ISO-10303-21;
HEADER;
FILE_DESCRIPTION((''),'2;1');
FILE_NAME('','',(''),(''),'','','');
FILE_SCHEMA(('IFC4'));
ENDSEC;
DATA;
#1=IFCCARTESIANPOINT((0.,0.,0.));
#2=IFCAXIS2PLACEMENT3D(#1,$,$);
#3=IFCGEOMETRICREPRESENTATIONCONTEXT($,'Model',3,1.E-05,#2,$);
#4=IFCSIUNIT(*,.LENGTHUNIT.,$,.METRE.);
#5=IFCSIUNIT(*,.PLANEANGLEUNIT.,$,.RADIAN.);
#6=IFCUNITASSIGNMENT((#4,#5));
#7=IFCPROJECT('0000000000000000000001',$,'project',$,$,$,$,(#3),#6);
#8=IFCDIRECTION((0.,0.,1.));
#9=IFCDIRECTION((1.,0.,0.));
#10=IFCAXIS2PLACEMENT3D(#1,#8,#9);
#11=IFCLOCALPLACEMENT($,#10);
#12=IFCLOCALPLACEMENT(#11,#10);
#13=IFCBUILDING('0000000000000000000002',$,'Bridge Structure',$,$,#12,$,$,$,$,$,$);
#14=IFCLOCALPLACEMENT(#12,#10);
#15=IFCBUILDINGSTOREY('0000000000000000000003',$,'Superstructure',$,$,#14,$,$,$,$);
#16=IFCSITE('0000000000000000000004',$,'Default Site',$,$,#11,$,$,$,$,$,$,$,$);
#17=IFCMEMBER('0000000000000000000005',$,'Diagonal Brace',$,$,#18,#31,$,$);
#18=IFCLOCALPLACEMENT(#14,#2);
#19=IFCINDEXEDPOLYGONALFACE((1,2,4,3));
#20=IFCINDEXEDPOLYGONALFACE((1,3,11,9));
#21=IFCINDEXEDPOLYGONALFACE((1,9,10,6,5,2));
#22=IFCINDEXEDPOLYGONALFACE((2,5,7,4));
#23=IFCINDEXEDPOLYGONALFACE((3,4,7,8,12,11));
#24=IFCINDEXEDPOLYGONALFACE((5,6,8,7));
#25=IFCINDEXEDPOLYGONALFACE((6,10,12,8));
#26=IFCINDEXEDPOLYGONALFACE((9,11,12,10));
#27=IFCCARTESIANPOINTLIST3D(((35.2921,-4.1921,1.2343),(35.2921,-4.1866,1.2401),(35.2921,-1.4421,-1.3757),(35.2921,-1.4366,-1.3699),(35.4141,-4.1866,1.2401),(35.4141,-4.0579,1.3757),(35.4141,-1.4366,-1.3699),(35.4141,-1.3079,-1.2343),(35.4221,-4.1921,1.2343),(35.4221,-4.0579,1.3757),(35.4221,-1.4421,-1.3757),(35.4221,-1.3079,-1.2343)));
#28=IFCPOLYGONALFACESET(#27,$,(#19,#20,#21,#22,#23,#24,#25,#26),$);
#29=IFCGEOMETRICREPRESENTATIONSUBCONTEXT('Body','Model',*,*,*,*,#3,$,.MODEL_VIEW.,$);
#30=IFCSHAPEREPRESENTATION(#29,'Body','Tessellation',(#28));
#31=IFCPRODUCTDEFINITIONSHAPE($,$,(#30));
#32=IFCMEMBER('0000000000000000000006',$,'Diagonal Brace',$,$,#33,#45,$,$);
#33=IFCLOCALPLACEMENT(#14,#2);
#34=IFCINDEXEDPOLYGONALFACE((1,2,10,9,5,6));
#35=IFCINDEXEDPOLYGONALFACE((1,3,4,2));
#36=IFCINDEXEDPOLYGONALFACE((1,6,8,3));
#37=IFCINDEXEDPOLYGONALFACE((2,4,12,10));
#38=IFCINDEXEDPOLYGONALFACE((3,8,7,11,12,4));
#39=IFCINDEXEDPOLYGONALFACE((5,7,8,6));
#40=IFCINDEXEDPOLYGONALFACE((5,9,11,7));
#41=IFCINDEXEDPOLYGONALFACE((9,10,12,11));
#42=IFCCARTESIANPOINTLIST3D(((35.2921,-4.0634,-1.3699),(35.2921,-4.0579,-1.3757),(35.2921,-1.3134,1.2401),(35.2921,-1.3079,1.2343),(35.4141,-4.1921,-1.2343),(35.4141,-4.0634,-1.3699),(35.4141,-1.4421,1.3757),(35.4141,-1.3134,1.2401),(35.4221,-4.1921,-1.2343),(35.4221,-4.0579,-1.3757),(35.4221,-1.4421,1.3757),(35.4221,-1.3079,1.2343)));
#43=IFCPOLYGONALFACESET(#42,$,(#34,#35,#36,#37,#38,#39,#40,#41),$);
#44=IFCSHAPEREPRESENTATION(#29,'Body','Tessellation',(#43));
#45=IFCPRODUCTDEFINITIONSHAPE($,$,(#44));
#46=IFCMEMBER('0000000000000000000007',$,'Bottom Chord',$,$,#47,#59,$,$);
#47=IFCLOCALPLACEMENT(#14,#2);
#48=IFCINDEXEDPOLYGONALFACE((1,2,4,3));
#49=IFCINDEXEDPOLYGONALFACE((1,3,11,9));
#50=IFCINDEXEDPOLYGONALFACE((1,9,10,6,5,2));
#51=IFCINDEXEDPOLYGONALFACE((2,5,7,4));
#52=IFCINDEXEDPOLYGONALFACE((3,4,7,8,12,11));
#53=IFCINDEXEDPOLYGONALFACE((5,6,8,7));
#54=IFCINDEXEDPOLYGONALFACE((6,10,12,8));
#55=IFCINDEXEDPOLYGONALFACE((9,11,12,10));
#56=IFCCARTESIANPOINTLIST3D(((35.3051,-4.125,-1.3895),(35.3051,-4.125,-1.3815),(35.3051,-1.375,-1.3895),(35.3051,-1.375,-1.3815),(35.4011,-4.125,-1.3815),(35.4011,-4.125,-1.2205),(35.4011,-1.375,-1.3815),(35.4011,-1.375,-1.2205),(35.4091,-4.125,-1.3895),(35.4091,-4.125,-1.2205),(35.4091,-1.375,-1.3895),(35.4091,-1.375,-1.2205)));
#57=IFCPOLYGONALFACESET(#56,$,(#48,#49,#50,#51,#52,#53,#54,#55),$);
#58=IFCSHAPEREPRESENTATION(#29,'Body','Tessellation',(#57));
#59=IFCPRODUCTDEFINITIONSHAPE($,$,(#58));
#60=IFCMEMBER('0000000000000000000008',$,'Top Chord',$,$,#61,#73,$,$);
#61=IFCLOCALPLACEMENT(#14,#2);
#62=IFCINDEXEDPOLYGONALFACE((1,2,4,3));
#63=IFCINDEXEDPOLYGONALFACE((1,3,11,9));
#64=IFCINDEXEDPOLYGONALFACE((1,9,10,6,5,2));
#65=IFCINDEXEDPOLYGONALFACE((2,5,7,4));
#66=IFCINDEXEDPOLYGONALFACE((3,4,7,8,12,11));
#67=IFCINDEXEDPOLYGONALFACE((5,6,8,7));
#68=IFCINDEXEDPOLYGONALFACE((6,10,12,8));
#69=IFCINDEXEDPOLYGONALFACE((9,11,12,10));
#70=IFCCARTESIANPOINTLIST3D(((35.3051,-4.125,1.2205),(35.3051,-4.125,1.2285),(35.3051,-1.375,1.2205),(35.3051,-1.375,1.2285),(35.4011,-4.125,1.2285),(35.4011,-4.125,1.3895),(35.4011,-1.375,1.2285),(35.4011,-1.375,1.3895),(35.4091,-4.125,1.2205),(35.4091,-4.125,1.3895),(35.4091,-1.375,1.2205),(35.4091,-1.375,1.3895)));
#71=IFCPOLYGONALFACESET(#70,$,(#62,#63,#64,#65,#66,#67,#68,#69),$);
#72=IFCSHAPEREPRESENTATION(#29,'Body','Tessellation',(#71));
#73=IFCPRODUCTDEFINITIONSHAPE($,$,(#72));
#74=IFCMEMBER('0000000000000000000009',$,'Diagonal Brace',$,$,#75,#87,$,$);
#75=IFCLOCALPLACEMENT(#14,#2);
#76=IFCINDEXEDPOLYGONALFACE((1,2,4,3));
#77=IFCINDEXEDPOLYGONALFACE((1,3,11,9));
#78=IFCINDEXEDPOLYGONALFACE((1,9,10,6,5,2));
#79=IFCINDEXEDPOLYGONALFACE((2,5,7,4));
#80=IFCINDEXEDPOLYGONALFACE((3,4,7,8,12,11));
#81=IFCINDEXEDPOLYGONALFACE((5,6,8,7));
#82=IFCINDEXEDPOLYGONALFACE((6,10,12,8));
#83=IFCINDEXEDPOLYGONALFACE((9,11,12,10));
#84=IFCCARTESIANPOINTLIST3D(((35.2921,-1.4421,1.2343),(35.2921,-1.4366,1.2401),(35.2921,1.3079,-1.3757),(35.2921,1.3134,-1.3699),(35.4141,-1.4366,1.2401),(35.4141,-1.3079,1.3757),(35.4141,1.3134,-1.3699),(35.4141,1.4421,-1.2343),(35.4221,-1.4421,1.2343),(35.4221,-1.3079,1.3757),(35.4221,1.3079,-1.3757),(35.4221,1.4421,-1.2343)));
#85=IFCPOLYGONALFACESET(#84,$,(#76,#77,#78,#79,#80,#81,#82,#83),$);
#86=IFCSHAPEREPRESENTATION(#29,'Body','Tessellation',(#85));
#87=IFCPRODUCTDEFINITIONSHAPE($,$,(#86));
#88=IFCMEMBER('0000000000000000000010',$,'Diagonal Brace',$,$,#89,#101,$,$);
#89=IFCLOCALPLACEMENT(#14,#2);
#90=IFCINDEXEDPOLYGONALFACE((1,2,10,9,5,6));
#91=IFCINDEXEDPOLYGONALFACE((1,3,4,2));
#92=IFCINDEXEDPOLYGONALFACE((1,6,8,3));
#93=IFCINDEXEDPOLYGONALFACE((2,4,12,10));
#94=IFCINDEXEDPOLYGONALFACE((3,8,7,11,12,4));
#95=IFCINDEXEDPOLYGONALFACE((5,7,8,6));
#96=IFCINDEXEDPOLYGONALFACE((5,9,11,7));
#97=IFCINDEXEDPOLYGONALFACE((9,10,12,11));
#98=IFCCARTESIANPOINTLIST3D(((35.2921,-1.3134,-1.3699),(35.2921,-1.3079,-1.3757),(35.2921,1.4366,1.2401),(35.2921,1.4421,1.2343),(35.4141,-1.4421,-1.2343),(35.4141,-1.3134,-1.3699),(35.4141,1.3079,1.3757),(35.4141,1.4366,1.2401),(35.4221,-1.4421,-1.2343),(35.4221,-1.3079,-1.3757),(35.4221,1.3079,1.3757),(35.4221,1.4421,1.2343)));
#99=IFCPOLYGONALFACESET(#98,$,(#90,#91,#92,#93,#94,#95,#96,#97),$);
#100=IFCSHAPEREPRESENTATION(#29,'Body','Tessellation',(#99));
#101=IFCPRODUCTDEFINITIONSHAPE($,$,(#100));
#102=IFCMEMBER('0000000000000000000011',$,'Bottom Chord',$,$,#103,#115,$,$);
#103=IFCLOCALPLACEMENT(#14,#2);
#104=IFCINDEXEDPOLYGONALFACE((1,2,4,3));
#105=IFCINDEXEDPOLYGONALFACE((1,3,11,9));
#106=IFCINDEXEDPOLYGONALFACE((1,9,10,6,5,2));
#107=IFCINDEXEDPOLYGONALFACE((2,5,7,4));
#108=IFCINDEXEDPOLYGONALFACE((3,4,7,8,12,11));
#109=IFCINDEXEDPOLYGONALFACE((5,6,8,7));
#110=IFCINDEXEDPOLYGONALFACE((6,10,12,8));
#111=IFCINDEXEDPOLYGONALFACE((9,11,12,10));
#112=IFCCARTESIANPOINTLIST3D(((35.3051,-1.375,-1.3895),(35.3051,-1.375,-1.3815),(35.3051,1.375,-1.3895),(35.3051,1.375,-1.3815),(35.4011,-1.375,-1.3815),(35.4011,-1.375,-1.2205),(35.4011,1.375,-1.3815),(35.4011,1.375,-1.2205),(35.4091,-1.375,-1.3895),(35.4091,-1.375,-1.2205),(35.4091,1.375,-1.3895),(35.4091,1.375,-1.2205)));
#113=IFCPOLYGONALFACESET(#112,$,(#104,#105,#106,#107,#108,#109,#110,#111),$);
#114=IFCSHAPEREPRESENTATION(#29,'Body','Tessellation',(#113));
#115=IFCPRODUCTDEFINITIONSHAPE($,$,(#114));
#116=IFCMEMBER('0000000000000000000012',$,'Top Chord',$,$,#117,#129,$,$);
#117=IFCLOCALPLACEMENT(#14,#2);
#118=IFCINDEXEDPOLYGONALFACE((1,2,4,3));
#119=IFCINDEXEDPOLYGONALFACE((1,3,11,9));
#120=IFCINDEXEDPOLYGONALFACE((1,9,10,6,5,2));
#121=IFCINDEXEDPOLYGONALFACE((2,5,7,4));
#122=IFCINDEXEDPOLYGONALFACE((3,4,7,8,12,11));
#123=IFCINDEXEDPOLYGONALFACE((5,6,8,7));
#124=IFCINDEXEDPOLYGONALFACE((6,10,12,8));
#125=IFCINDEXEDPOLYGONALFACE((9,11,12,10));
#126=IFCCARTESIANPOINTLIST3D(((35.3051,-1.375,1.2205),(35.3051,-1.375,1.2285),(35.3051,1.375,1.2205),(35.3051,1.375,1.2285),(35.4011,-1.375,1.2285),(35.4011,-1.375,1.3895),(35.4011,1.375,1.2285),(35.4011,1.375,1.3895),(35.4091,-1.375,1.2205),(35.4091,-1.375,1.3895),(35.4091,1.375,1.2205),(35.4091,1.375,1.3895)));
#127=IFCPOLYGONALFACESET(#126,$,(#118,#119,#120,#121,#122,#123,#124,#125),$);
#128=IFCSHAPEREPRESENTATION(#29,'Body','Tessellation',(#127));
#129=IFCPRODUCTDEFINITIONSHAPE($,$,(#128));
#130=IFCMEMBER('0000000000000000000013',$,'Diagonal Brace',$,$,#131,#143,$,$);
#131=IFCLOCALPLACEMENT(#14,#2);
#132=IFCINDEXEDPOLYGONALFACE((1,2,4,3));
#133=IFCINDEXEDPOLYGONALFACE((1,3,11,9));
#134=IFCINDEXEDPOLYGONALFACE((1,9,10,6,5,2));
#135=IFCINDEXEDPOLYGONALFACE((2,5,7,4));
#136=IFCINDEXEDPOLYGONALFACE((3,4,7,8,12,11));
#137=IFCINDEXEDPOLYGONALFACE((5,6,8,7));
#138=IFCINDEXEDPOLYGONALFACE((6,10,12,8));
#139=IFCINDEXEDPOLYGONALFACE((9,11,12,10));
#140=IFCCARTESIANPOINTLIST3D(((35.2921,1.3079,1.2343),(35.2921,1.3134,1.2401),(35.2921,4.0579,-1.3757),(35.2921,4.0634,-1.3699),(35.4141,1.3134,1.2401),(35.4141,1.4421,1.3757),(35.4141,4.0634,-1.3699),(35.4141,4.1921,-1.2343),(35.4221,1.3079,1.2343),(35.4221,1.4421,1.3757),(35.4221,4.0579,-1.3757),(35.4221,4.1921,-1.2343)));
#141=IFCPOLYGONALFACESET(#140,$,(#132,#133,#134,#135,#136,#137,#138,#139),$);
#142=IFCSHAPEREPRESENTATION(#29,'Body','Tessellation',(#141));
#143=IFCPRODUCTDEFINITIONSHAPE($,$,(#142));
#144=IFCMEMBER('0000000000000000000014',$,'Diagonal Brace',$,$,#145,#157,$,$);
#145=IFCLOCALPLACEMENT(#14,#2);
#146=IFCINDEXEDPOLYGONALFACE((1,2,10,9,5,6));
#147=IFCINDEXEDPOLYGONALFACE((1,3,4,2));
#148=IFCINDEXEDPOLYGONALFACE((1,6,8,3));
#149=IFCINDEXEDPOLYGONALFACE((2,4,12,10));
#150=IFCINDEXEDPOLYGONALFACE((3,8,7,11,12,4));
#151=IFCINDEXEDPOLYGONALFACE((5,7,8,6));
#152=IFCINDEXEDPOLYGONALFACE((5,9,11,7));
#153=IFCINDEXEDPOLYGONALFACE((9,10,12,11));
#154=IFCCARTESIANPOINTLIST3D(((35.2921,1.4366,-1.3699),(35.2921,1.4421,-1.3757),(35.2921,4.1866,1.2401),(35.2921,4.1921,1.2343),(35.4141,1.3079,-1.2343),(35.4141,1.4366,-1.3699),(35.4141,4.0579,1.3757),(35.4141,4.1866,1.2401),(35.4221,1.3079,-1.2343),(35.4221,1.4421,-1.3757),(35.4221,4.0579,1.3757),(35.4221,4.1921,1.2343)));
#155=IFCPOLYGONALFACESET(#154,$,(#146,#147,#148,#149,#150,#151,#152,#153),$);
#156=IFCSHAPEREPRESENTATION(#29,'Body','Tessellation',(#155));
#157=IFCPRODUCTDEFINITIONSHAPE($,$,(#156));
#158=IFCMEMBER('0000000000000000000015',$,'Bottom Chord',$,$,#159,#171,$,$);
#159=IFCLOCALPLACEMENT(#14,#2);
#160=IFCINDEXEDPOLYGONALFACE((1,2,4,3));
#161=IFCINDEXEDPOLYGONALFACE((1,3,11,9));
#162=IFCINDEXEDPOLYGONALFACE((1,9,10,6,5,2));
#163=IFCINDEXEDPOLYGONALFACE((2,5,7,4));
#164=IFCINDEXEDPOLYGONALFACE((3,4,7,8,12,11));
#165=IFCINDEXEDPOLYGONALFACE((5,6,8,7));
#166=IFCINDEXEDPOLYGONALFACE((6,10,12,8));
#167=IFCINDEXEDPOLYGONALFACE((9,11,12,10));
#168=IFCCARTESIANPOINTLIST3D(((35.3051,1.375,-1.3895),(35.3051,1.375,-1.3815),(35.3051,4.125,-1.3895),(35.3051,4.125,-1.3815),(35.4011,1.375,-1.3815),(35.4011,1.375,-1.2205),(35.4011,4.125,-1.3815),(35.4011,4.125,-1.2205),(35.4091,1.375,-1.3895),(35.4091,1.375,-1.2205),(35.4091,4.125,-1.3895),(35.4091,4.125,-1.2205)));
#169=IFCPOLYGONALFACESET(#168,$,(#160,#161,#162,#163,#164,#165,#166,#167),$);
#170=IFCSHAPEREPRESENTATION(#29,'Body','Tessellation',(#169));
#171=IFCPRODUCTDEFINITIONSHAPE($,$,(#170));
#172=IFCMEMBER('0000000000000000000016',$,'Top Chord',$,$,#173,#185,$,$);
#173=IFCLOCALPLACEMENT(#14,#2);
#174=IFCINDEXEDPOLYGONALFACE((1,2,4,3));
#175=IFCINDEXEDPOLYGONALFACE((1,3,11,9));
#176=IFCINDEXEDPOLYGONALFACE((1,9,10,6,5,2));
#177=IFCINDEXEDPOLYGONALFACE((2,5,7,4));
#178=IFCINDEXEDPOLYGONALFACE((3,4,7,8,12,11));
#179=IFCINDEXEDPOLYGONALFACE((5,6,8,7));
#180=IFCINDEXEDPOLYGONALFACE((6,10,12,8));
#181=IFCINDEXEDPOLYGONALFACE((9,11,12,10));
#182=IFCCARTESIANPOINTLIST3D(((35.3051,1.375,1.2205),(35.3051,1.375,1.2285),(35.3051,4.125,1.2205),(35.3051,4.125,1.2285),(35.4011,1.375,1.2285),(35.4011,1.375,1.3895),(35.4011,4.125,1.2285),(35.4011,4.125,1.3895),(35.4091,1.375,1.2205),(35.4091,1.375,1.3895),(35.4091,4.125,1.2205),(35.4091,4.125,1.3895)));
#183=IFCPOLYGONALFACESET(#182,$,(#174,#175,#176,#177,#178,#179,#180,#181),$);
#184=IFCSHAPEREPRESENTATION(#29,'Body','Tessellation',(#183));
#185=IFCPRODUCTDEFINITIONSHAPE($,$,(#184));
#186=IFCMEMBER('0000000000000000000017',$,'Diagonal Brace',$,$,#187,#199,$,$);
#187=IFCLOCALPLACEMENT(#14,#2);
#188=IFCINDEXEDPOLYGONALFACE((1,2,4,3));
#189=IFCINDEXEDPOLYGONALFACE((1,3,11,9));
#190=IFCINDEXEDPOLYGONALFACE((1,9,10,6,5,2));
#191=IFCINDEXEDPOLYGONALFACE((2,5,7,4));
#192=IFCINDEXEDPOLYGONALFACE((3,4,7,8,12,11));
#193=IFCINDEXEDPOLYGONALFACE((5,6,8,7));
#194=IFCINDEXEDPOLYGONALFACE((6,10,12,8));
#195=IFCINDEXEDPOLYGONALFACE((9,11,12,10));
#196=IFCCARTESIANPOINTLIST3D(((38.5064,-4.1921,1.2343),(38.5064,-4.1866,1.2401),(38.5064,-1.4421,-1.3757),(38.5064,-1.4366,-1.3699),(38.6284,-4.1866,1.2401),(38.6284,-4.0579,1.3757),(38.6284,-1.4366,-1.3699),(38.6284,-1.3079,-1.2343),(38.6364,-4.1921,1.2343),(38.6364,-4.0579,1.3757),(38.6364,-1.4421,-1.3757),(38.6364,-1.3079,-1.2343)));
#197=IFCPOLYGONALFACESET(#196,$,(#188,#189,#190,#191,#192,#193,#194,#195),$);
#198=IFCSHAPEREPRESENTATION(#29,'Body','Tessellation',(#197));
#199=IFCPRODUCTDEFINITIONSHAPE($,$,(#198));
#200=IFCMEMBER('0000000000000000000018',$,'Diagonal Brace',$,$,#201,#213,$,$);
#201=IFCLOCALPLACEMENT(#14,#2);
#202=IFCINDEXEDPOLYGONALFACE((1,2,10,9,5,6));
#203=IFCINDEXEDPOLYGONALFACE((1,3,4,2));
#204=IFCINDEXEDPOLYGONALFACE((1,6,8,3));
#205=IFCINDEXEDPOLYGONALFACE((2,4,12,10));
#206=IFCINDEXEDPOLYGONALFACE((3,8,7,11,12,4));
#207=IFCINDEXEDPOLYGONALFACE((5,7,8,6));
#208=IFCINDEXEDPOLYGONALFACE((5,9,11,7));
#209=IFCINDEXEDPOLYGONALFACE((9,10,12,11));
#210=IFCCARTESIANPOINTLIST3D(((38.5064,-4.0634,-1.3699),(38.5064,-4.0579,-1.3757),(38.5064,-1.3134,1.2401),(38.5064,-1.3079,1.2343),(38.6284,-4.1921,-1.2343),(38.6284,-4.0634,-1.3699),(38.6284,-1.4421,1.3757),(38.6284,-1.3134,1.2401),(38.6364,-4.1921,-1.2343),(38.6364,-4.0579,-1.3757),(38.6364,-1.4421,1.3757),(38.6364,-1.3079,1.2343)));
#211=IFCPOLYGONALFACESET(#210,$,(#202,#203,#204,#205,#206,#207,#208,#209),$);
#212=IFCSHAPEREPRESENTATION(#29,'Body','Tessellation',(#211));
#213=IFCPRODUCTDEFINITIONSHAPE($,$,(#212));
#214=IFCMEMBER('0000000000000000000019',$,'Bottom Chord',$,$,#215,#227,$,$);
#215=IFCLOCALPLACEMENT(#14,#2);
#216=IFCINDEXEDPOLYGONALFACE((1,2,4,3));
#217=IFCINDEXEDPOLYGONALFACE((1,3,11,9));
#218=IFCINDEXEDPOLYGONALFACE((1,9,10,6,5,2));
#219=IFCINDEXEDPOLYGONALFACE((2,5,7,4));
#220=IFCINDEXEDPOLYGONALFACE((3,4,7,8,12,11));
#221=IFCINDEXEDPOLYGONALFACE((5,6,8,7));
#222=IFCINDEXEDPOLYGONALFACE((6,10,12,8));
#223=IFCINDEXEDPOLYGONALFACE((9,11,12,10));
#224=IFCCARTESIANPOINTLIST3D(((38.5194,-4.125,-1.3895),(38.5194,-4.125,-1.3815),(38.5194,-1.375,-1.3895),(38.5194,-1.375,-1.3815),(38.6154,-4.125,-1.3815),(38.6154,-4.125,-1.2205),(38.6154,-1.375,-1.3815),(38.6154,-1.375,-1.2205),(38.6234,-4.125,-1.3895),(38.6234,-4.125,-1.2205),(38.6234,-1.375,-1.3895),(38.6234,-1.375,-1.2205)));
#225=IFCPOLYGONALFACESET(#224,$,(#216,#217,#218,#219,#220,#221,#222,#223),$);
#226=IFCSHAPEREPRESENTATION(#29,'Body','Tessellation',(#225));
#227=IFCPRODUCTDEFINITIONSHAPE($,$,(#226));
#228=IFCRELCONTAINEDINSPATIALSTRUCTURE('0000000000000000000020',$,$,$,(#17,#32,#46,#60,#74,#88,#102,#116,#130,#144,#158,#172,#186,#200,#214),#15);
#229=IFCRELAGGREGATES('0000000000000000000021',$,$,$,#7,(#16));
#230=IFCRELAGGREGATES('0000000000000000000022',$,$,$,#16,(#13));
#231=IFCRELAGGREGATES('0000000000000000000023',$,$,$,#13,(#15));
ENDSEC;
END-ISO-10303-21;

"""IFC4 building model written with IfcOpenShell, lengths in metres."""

from ifc_helpers import new_model, si_unit, frame, origin, origin_with_axes, origin_2d_with_axis, place, context, subcontext, project, spatial, l_section, extrude, element, save


model = new_model("IFC4")

# Units and contexts
model_context = context("Model", 3, precision=1e-05, world=origin())
body_context = subcontext(model_context, "Body", "Model", "MODEL_VIEW")
ifc_project = project(units=[si_unit("LENGTHUNIT", "METRE"), si_unit("PLANEANGLEUNIT", "RADIAN")], contexts=[model_context])

# Site, building, storey
site_placement = place(None, origin_with_axes())
site = spatial("IfcSite", under=ifc_project, at=site_placement, Name="Default Site")
building_placement = place(site_placement, origin_with_axes())
building = spatial("IfcBuilding", under=site, at=building_placement, Name="Bridge Structure")
storey_placement = place(building_placement, origin_with_axes())
storey = spatial("IfcBuildingStorey", under=building, at=storey_placement, Name="Superstructure")

# Members
for number, where, z_axis, x_axis, name in (
    (1, (35.3571, -4.125, 1.305), (0.0, 0.725329, -0.688403), (-1.0, 0.0, 0.0), "Diagonal Brace"),
    (2, (35.3571, -4.125, -1.305), (0.0, 0.725329, 0.688403), (-1.0, 0.0, 0.0), "Diagonal Brace"),
):
    element("IfcMember", number, at=place(storey_placement, frame(where, z_axis=z_axis, x_axis=x_axis)), inside=storey, Name=name, context=body_context, shape_type="SweptSolid", body=[
        extrude(l_section(Depth=0.195, Width=0.13, Thickness=0.008, at=origin_2d_with_axis()), origin_with_axes(), (0.0, 0.0, 1.0), 3.7914),
    ])
for number, where, z_axis, x_axis, name in (
    (3, (35.3571, -4.125, -1.305), (0.0, 1.0, 0.0), (-1.0, 0.0, 0.0), "Bottom Chord"),
    (4, (35.3571, -4.125, 1.305), (0.0, 1.0, 0.0), (-1.0, 0.0, 0.0), "Top Chord"),
):
    element("IfcMember", number, at=place(storey_placement, frame(where, z_axis=z_axis, x_axis=x_axis)), inside=storey, Name=name, context=body_context, shape_type="SweptSolid", body=[
        extrude(l_section(Depth=0.169, Width=0.104, Thickness=0.008, at=origin_2d_with_axis()), origin_with_axes(), (0.0, 0.0, 1.0), 2.75),
    ])
for number, where, z_axis, x_axis, name in (
    (5, (35.3571, -1.375, 1.305), (0.0, 0.725329, -0.688403), (-1.0, 0.0, 0.0), "Diagonal Brace"),
    (6, (35.3571, -1.375, -1.305), (0.0, 0.725329, 0.688403), (-1.0, 0.0, 0.0), "Diagonal Brace"),
):
    element("IfcMember", number, at=place(storey_placement, frame(where, z_axis=z_axis, x_axis=x_axis)), inside=storey, Name=name, context=body_context, shape_type="SweptSolid", body=[
        extrude(l_section(Depth=0.195, Width=0.13, Thickness=0.008, at=origin_2d_with_axis()), origin_with_axes(), (0.0, 0.0, 1.0), 3.7914),
    ])
for number, where, z_axis, x_axis, name in (
    (7, (35.3571, -1.375, -1.305), (0.0, 1.0, 0.0), (-1.0, 0.0, 0.0), "Bottom Chord"),
    (8, (35.3571, -1.375, 1.305), (0.0, 1.0, 0.0), (-1.0, 0.0, 0.0), "Top Chord"),
):
    element("IfcMember", number, at=place(storey_placement, frame(where, z_axis=z_axis, x_axis=x_axis)), inside=storey, Name=name, context=body_context, shape_type="SweptSolid", body=[
        extrude(l_section(Depth=0.169, Width=0.104, Thickness=0.008, at=origin_2d_with_axis()), origin_with_axes(), (0.0, 0.0, 1.0), 2.75),
    ])
for number, where, z_axis, x_axis, name in (
    (9, (35.3571, 1.375, 1.305), (0.0, 0.725329, -0.688403), (-1.0, 0.0, 0.0), "Diagonal Brace"),
    (10, (35.3571, 1.375, -1.305), (0.0, 0.725329, 0.688403), (-1.0, 0.0, 0.0), "Diagonal Brace"),
):
    element("IfcMember", number, at=place(storey_placement, frame(where, z_axis=z_axis, x_axis=x_axis)), inside=storey, Name=name, context=body_context, shape_type="SweptSolid", body=[
        extrude(l_section(Depth=0.195, Width=0.13, Thickness=0.008, at=origin_2d_with_axis()), origin_with_axes(), (0.0, 0.0, 1.0), 3.7914),
    ])
for number, where, z_axis, x_axis, name in (
    (11, (35.3571, 1.375, -1.305), (0.0, 1.0, 0.0), (-1.0, 0.0, 0.0), "Bottom Chord"),
    (12, (35.3571, 1.375, 1.305), (0.0, 1.0, 0.0), (-1.0, 0.0, 0.0), "Top Chord"),
):
    element("IfcMember", number, at=place(storey_placement, frame(where, z_axis=z_axis, x_axis=x_axis)), inside=storey, Name=name, context=body_context, shape_type="SweptSolid", body=[
        extrude(l_section(Depth=0.169, Width=0.104, Thickness=0.008, at=origin_2d_with_axis()), origin_with_axes(), (0.0, 0.0, 1.0), 2.75),
    ])
for number, where, z_axis, x_axis, name in (
    (13, (38.5714, -4.125, 1.305), (0.0, 0.725329, -0.688403), (-1.0, 0.0, 0.0), "Diagonal Brace"),
    (14, (38.5714, -4.125, -1.305), (0.0, 0.725329, 0.688403), (-1.0, 0.0, 0.0), "Diagonal Brace"),
):
    element("IfcMember", number, at=place(storey_placement, frame(where, z_axis=z_axis, x_axis=x_axis)), inside=storey, Name=name, context=body_context, shape_type="SweptSolid", body=[
        extrude(l_section(Depth=0.195, Width=0.13, Thickness=0.008, at=origin_2d_with_axis()), origin_with_axes(), (0.0, 0.0, 1.0), 3.7914),
    ])
for number, where, z_axis, x_axis, name in (
    (15, (38.5714, -4.125, -1.305), (0.0, 1.0, 0.0), (-1.0, 0.0, 0.0), "Bottom Chord"),
):
    element("IfcMember", number, at=place(storey_placement, frame(where, z_axis=z_axis, x_axis=x_axis)), inside=storey, Name=name, context=body_context, shape_type="SweptSolid", body=[
        extrude(l_section(Depth=0.169, Width=0.104, Thickness=0.008, at=origin_2d_with_axis()), origin_with_axes(), (0.0, 0.0, 1.0), 2.75),
    ])

save(model, "model.ifc")
